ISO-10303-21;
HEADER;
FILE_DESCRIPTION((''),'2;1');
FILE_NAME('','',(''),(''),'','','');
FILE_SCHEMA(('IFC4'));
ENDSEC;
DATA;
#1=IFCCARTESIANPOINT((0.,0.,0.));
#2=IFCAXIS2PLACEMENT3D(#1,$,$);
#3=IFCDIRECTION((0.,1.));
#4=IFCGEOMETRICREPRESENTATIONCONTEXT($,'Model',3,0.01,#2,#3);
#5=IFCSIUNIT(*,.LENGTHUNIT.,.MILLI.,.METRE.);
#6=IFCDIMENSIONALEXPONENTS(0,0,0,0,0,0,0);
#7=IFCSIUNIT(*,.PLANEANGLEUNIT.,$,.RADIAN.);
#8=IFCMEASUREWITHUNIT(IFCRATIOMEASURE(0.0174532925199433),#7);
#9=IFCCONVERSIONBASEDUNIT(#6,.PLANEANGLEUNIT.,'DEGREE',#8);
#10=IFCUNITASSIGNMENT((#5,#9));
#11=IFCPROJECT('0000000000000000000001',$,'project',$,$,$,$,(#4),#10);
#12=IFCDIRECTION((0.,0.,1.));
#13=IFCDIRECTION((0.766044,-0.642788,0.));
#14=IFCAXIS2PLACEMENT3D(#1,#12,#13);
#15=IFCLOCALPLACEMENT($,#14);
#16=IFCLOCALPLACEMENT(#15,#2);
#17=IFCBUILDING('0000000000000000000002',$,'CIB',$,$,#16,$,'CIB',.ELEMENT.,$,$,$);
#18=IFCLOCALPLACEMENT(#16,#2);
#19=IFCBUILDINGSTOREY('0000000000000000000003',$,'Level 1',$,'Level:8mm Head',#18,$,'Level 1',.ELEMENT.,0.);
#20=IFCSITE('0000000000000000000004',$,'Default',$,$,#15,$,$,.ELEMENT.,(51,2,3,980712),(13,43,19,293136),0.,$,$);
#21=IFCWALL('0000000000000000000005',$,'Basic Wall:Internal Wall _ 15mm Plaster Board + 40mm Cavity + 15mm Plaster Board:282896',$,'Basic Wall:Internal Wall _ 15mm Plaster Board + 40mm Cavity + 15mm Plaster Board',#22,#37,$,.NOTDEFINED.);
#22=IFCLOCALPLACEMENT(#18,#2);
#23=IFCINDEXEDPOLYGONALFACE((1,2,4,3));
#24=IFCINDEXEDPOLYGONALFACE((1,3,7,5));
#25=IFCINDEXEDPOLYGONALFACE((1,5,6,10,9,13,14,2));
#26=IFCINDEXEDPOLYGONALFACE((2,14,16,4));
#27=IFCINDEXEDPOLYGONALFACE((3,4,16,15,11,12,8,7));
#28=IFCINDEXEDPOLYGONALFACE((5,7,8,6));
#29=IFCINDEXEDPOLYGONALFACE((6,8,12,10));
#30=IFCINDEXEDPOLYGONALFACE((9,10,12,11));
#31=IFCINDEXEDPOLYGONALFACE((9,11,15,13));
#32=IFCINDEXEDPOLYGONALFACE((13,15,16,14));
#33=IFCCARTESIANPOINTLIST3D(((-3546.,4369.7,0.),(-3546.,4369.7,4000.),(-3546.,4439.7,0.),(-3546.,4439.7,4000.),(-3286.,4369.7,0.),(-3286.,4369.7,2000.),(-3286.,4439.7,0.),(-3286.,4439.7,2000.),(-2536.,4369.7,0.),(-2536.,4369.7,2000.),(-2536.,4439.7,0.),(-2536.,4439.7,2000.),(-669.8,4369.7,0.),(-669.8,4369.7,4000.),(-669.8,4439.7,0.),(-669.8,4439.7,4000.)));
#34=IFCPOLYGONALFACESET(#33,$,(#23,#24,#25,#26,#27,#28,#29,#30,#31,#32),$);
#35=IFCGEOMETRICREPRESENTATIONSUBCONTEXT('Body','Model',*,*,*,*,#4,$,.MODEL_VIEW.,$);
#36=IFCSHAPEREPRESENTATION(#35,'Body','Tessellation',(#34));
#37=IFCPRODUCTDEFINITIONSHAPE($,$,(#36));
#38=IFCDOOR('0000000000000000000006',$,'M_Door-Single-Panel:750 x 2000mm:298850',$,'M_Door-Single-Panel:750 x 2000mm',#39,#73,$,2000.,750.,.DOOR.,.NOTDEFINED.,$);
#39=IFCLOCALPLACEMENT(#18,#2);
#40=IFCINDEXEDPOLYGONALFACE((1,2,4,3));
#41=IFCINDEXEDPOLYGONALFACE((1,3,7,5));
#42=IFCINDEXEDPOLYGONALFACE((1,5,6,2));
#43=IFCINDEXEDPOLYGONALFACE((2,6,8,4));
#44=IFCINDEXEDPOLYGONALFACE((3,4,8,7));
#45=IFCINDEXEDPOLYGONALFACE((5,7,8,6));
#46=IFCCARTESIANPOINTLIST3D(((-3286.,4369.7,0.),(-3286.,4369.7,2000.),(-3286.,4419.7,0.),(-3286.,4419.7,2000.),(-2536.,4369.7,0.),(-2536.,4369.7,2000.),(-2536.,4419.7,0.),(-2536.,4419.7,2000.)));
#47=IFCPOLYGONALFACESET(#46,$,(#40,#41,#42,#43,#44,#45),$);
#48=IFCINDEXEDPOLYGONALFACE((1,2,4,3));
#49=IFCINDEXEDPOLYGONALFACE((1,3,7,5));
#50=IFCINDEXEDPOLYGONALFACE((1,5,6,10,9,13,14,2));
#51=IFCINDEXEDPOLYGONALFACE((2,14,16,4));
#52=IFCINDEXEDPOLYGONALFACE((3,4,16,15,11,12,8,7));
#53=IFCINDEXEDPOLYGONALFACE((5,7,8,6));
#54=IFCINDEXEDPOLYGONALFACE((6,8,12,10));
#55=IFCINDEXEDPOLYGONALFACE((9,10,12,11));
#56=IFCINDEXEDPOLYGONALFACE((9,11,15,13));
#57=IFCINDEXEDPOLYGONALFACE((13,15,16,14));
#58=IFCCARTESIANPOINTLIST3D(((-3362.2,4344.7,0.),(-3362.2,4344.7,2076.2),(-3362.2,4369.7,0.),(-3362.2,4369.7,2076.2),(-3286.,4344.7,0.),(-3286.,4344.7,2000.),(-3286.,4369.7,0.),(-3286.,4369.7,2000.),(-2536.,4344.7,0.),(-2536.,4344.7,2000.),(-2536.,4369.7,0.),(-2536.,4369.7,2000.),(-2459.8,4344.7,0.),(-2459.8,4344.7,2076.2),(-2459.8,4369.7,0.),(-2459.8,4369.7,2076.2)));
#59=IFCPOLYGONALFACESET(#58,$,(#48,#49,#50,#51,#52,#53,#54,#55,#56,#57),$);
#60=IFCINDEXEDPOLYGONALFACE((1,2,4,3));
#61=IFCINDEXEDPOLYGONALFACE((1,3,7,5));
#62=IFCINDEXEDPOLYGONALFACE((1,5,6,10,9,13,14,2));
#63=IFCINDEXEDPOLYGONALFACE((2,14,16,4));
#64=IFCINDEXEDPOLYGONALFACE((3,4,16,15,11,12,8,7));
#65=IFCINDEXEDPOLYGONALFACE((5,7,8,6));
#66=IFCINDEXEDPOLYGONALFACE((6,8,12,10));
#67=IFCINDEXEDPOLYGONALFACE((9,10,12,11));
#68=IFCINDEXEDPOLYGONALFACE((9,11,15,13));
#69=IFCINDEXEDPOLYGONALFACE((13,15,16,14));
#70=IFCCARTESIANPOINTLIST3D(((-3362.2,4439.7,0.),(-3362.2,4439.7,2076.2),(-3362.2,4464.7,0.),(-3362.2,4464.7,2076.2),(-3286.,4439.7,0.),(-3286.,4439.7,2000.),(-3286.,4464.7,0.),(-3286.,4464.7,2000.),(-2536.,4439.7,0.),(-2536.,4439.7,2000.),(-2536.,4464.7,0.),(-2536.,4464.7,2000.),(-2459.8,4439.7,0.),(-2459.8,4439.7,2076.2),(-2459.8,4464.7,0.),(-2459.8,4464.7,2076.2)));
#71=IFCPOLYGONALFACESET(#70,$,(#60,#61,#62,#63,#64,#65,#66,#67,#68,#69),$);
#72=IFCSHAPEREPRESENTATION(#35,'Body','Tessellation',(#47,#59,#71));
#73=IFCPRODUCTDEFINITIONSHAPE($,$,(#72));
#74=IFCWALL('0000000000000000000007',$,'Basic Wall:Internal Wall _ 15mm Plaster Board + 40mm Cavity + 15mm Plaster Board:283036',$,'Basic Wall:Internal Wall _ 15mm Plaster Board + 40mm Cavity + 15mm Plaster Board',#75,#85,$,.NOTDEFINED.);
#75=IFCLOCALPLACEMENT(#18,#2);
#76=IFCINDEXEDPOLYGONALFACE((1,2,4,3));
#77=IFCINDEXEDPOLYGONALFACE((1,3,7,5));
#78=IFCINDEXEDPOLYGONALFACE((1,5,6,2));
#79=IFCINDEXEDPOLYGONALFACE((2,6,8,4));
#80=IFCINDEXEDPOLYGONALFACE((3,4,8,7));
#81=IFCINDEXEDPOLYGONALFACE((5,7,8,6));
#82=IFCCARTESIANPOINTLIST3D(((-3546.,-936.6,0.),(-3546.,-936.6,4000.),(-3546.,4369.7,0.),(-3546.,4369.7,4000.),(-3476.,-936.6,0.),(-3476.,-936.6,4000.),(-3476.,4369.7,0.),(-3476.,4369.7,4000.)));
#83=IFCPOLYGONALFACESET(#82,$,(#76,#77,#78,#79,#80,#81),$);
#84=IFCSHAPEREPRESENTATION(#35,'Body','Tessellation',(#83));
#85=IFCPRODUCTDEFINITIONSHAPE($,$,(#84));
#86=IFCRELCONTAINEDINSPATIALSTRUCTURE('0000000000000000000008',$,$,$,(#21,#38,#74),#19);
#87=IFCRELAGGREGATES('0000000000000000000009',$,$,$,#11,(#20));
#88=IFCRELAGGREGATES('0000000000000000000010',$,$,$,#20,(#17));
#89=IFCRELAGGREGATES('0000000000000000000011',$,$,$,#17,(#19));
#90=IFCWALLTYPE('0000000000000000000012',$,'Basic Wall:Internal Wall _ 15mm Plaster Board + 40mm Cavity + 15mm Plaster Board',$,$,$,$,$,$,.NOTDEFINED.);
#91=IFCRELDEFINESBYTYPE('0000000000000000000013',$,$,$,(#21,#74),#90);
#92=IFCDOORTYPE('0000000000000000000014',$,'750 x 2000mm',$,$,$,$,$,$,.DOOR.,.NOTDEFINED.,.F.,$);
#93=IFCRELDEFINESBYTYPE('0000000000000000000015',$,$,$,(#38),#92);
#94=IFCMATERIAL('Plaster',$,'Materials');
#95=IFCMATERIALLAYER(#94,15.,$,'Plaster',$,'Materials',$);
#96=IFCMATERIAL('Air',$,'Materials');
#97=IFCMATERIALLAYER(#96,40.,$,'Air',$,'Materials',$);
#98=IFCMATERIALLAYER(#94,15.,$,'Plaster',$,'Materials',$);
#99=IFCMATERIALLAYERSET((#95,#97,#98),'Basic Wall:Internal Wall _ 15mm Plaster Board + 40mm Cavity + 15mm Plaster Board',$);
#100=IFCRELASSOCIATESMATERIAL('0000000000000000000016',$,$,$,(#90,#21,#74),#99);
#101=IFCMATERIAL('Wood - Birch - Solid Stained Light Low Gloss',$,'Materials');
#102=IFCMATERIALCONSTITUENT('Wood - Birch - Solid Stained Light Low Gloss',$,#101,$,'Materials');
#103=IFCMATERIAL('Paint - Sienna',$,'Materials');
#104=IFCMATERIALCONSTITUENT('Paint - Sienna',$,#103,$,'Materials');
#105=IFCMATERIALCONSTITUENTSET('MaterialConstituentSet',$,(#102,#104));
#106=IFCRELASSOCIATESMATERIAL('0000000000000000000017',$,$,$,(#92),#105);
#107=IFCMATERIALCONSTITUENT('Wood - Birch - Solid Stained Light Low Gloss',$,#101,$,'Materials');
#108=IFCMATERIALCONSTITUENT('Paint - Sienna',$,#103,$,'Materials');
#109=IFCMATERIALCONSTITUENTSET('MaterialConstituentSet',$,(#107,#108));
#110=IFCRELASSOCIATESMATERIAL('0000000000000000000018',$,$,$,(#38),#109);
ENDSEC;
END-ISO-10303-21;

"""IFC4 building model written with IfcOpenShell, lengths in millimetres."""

from ifc_helpers import new_model, entity, si_unit, converted_unit, direction, frame, frame_2d, origin, origin_2d_with_axis, place, context, subcontext, project, spatial, polyline, rectangle, outline, extrude, source, transform, mapped, material, layer, layer_set, layer_usage, constituent, constituent_set, type_object, type_shapes, element, fill, save


model = new_model("IFC4")

# Units and contexts
model_context = context("Model", 3, precision=0.01, world=origin(), true_north=direction((0.0, 1.0)))
body_context = subcontext(model_context, "Body", "Model", "MODEL_VIEW")
ifc_project = project(units=[si_unit("LENGTHUNIT", "METRE", prefix="MILLI"), converted_unit("PLANEANGLEUNIT", "DEGREE", entity("IfcRatioMeasure", 0.0174532925199433), si_unit("PLANEANGLEUNIT", "RADIAN"), dimensions=[0, 0, 0, 0, 0, 0, 0])], contexts=[model_context])

# Site, building, storey
site_placement = place(None, frame((0.0, 0.0, 0.0), z_axis=(0.0, 0.0, 1.0), x_axis=(0.766044, -0.642788, 0.0)))
site = spatial("IfcSite", under=ifc_project, at=site_placement, Name="Default", CompositionType="ELEMENT", RefLatitude=(51, 2, 3, 980712), RefLongitude=(13, 43, 19, 293136), RefElevation=0.0)
building_placement = place(site_placement, origin())
building = spatial("IfcBuilding", under=site, at=building_placement, Name="CIB", LongName="CIB", CompositionType="ELEMENT")
storey_placement = place(building_placement, origin())
storey = spatial("IfcBuildingStorey", under=building, at=storey_placement, Name="Level 1", ObjectType="Level:8mm Head", LongName="Level 1", CompositionType="ELEMENT", Elevation=0.0)

# Shared definitions
ifc_material_1 = material(Name="Plaster", Category="Materials")
ifc_layer_1 = layer(ifc_material_1, 15.0, Name="Plaster", Category="Materials")
ifc_material_2 = material(Name="Air", Category="Materials")
ifc_layer_2 = layer(ifc_material_2, 40.0, Name="Air", Category="Materials")
ifc_layer_3 = layer(ifc_material_1, 15.0, Name="Plaster", Category="Materials")
ifc_layer_set_1 = layer_set([ifc_layer_1, ifc_layer_2, ifc_layer_3], Name="Basic Wall:Internal Wall _ 15mm Plaster Board + 40mm Cavity + 15mm Plaster Board")
wall_type_1 = type_object("IfcWallType", Name="Basic Wall:Internal Wall _ 15mm Plaster Board + 40mm Cavity + 15mm Plaster Board", PredefinedType="NOTDEFINED", material=ifc_layer_set_1)
ifc_material_3 = material(Name="Wood - Birch - Solid Stained Light Low Gloss", Category="Materials")
ifc_material_4 = material(Name="Paint - Sienna", Category="Materials")

# Wall, opening, door
ifc_layer_usage_1 = layer_usage(ifc_layer_set_1, "AXIS2", "NEGATIVE", 35.0)
wall_1_placement = place(storey_placement, frame((-669.8, 4404.7, 0.0), z_axis=(0.0, 0.0, 1.0), x_axis=(-1.0, 0.0, 0.0)))
wall_1 = element("IfcWall", 1, at=wall_1_placement, inside=storey, type_object=wall_type_1, material=ifc_layer_usage_1, Name="Basic Wall:Internal Wall _ 15mm Plaster Board + 40mm Cavity + 15mm Plaster Board:282896", ObjectType="Basic Wall:Internal Wall _ 15mm Plaster Board + 40mm Cavity + 15mm Plaster Board", PredefinedType="NOTDEFINED", context=body_context, shape_type="SweptSolid", body=[
    extrude(rectangle(XDim=2876.2, YDim=70.0, at=frame_2d((1438.1, 0.0), x_axis=(-1.0, 0.0))), origin(), (0.0, 0.0, 1.0), 4000.0),
])
opening_1_placement = place(wall_1_placement, frame((1866.2, -35.0, 0.0)))
opening_1 = element("IfcOpeningElement", 2, at=opening_1_placement, cuts=wall_1, ObjectType="Opening", PredefinedType="OPENING", context=body_context, shape_type="SweptSolid", body=[
    extrude(rectangle(XDim=750.0, YDim=2000.0, at=frame_2d((1000.0, 375.0), x_axis=(0.0, 1.0))), frame((0.0, 0.0, 0.0), z_axis=(0.0, 1.0, 0.0), x_axis=(0.0, 0.0, 1.0)), (0.0, 0.0, 1.0), 70.0),
])
ifc_constituent_1 = constituent(ifc_material_3, Name="Wood - Birch - Solid Stained Light Low Gloss", Category="Materials")
ifc_constituent_2 = constituent(ifc_material_4, Name="Paint - Sienna", Category="Materials")
ifc_constituent_set_1 = constituent_set(constituents=[ifc_constituent_1, ifc_constituent_2], Name="MaterialConstituentSet")
ifc_constituent_3 = constituent(ifc_material_3, Name="Wood - Birch - Solid Stained Light Low Gloss", Category="Materials")
ifc_constituent_4 = constituent(ifc_material_4, Name="Paint - Sienna", Category="Materials")
ifc_constituent_set_2 = constituent_set(constituents=[ifc_constituent_3, ifc_constituent_4], Name="MaterialConstituentSet")
door_type_1 = type_object("IfcDoorType", Name="750 x 2000mm", OperationType="NOTDEFINED", ParameterTakesPrecedence=False, PredefinedType="DOOR", material=ifc_constituent_set_2)
shared_shape_1 = source(origin(), body_context, "Body", "SweptSolid", [
    extrude(rectangle(XDim=50.0, YDim=750.0, at=origin_2d_with_axis()), frame((375.0, 45.0, 0.0), z_axis=(0.0, 0.0, 1.0), x_axis=(0.0, 1.0, 0.0)), (0.0, 0.0, 1.0), 2000.0),
    extrude(outline(polyline([(-451.2, -1057.2), (451.2, -1057.2), (451.2, 1019.0), (375.0, 1019.0), (375.0, -981.0), (-375.0, -981.0), (-375.0, 1019.0), (-451.2, 1019.0), (-451.2, -1057.2)])), frame((375.0, 70.0, 1019.0), z_axis=(0.0, 1.0, 0.0), x_axis=(1.0, 0.0, 0.0)), (0.0, 0.0, 1.0), 25.0),
    extrude(outline(polyline([(-1057.2, -451.2), (1019.0, -451.2), (1019.0, -375.0), (-981.0, -375.0), (-981.0, 375.0), (1019.0, 375.0), (1019.0, 451.2), (-1057.2, 451.2), (-1057.2, -451.2)])), frame((375.0, -25.0, 1019.0), z_axis=(0.0, 1.0, 0.0), x_axis=(0.0, 0.0, -1.0)), (0.0, 0.0, 1.0), 25.0),
])
type_shapes(door_type_1, [shared_shape_1])
door_1_placement = place(opening_1_placement, origin())
door_1 = element("IfcDoor", 3, at=door_1_placement, inside=storey, type_object=door_type_1, material=ifc_constituent_set_1, Name="M_Door-Single-Panel:750 x 2000mm:298850", ObjectType="M_Door-Single-Panel:750 x 2000mm", OperationType="NOTDEFINED", OverallHeight=2000.0, OverallWidth=750.0, PredefinedType="DOOR", context=body_context, shape_type="MappedRepresentation", body=[
    mapped(shared_shape_1, transform((0.0, 0.0, 0.0), scale=1.0)),
])
fill(opening_1, door_1)

# Wall
ifc_layer_usage_2 = layer_usage(ifc_layer_set_1, "AXIS2", "NEGATIVE", 35.0)
wall_2_placement = place(storey_placement, frame((-3511.0, 4369.7, 0.0), z_axis=(0.0, 0.0, 1.0), x_axis=(0.0, -1.0, 0.0)))
element("IfcWall", 4, at=wall_2_placement, inside=storey, type_object=wall_type_1, material=ifc_layer_usage_2, Name="Basic Wall:Internal Wall _ 15mm Plaster Board + 40mm Cavity + 15mm Plaster Board:283036", ObjectType="Basic Wall:Internal Wall _ 15mm Plaster Board + 40mm Cavity + 15mm Plaster Board", PredefinedType="NOTDEFINED", context=body_context, shape_type="SweptSolid", body=[
    extrude(rectangle(XDim=5306.2, YDim=70.0, at=frame_2d((2653.1, 0.0), x_axis=(-1.0, 0.0))), origin(), (0.0, 0.0, 1.0), 4000.0),
])

save(model, "model.ifc")
